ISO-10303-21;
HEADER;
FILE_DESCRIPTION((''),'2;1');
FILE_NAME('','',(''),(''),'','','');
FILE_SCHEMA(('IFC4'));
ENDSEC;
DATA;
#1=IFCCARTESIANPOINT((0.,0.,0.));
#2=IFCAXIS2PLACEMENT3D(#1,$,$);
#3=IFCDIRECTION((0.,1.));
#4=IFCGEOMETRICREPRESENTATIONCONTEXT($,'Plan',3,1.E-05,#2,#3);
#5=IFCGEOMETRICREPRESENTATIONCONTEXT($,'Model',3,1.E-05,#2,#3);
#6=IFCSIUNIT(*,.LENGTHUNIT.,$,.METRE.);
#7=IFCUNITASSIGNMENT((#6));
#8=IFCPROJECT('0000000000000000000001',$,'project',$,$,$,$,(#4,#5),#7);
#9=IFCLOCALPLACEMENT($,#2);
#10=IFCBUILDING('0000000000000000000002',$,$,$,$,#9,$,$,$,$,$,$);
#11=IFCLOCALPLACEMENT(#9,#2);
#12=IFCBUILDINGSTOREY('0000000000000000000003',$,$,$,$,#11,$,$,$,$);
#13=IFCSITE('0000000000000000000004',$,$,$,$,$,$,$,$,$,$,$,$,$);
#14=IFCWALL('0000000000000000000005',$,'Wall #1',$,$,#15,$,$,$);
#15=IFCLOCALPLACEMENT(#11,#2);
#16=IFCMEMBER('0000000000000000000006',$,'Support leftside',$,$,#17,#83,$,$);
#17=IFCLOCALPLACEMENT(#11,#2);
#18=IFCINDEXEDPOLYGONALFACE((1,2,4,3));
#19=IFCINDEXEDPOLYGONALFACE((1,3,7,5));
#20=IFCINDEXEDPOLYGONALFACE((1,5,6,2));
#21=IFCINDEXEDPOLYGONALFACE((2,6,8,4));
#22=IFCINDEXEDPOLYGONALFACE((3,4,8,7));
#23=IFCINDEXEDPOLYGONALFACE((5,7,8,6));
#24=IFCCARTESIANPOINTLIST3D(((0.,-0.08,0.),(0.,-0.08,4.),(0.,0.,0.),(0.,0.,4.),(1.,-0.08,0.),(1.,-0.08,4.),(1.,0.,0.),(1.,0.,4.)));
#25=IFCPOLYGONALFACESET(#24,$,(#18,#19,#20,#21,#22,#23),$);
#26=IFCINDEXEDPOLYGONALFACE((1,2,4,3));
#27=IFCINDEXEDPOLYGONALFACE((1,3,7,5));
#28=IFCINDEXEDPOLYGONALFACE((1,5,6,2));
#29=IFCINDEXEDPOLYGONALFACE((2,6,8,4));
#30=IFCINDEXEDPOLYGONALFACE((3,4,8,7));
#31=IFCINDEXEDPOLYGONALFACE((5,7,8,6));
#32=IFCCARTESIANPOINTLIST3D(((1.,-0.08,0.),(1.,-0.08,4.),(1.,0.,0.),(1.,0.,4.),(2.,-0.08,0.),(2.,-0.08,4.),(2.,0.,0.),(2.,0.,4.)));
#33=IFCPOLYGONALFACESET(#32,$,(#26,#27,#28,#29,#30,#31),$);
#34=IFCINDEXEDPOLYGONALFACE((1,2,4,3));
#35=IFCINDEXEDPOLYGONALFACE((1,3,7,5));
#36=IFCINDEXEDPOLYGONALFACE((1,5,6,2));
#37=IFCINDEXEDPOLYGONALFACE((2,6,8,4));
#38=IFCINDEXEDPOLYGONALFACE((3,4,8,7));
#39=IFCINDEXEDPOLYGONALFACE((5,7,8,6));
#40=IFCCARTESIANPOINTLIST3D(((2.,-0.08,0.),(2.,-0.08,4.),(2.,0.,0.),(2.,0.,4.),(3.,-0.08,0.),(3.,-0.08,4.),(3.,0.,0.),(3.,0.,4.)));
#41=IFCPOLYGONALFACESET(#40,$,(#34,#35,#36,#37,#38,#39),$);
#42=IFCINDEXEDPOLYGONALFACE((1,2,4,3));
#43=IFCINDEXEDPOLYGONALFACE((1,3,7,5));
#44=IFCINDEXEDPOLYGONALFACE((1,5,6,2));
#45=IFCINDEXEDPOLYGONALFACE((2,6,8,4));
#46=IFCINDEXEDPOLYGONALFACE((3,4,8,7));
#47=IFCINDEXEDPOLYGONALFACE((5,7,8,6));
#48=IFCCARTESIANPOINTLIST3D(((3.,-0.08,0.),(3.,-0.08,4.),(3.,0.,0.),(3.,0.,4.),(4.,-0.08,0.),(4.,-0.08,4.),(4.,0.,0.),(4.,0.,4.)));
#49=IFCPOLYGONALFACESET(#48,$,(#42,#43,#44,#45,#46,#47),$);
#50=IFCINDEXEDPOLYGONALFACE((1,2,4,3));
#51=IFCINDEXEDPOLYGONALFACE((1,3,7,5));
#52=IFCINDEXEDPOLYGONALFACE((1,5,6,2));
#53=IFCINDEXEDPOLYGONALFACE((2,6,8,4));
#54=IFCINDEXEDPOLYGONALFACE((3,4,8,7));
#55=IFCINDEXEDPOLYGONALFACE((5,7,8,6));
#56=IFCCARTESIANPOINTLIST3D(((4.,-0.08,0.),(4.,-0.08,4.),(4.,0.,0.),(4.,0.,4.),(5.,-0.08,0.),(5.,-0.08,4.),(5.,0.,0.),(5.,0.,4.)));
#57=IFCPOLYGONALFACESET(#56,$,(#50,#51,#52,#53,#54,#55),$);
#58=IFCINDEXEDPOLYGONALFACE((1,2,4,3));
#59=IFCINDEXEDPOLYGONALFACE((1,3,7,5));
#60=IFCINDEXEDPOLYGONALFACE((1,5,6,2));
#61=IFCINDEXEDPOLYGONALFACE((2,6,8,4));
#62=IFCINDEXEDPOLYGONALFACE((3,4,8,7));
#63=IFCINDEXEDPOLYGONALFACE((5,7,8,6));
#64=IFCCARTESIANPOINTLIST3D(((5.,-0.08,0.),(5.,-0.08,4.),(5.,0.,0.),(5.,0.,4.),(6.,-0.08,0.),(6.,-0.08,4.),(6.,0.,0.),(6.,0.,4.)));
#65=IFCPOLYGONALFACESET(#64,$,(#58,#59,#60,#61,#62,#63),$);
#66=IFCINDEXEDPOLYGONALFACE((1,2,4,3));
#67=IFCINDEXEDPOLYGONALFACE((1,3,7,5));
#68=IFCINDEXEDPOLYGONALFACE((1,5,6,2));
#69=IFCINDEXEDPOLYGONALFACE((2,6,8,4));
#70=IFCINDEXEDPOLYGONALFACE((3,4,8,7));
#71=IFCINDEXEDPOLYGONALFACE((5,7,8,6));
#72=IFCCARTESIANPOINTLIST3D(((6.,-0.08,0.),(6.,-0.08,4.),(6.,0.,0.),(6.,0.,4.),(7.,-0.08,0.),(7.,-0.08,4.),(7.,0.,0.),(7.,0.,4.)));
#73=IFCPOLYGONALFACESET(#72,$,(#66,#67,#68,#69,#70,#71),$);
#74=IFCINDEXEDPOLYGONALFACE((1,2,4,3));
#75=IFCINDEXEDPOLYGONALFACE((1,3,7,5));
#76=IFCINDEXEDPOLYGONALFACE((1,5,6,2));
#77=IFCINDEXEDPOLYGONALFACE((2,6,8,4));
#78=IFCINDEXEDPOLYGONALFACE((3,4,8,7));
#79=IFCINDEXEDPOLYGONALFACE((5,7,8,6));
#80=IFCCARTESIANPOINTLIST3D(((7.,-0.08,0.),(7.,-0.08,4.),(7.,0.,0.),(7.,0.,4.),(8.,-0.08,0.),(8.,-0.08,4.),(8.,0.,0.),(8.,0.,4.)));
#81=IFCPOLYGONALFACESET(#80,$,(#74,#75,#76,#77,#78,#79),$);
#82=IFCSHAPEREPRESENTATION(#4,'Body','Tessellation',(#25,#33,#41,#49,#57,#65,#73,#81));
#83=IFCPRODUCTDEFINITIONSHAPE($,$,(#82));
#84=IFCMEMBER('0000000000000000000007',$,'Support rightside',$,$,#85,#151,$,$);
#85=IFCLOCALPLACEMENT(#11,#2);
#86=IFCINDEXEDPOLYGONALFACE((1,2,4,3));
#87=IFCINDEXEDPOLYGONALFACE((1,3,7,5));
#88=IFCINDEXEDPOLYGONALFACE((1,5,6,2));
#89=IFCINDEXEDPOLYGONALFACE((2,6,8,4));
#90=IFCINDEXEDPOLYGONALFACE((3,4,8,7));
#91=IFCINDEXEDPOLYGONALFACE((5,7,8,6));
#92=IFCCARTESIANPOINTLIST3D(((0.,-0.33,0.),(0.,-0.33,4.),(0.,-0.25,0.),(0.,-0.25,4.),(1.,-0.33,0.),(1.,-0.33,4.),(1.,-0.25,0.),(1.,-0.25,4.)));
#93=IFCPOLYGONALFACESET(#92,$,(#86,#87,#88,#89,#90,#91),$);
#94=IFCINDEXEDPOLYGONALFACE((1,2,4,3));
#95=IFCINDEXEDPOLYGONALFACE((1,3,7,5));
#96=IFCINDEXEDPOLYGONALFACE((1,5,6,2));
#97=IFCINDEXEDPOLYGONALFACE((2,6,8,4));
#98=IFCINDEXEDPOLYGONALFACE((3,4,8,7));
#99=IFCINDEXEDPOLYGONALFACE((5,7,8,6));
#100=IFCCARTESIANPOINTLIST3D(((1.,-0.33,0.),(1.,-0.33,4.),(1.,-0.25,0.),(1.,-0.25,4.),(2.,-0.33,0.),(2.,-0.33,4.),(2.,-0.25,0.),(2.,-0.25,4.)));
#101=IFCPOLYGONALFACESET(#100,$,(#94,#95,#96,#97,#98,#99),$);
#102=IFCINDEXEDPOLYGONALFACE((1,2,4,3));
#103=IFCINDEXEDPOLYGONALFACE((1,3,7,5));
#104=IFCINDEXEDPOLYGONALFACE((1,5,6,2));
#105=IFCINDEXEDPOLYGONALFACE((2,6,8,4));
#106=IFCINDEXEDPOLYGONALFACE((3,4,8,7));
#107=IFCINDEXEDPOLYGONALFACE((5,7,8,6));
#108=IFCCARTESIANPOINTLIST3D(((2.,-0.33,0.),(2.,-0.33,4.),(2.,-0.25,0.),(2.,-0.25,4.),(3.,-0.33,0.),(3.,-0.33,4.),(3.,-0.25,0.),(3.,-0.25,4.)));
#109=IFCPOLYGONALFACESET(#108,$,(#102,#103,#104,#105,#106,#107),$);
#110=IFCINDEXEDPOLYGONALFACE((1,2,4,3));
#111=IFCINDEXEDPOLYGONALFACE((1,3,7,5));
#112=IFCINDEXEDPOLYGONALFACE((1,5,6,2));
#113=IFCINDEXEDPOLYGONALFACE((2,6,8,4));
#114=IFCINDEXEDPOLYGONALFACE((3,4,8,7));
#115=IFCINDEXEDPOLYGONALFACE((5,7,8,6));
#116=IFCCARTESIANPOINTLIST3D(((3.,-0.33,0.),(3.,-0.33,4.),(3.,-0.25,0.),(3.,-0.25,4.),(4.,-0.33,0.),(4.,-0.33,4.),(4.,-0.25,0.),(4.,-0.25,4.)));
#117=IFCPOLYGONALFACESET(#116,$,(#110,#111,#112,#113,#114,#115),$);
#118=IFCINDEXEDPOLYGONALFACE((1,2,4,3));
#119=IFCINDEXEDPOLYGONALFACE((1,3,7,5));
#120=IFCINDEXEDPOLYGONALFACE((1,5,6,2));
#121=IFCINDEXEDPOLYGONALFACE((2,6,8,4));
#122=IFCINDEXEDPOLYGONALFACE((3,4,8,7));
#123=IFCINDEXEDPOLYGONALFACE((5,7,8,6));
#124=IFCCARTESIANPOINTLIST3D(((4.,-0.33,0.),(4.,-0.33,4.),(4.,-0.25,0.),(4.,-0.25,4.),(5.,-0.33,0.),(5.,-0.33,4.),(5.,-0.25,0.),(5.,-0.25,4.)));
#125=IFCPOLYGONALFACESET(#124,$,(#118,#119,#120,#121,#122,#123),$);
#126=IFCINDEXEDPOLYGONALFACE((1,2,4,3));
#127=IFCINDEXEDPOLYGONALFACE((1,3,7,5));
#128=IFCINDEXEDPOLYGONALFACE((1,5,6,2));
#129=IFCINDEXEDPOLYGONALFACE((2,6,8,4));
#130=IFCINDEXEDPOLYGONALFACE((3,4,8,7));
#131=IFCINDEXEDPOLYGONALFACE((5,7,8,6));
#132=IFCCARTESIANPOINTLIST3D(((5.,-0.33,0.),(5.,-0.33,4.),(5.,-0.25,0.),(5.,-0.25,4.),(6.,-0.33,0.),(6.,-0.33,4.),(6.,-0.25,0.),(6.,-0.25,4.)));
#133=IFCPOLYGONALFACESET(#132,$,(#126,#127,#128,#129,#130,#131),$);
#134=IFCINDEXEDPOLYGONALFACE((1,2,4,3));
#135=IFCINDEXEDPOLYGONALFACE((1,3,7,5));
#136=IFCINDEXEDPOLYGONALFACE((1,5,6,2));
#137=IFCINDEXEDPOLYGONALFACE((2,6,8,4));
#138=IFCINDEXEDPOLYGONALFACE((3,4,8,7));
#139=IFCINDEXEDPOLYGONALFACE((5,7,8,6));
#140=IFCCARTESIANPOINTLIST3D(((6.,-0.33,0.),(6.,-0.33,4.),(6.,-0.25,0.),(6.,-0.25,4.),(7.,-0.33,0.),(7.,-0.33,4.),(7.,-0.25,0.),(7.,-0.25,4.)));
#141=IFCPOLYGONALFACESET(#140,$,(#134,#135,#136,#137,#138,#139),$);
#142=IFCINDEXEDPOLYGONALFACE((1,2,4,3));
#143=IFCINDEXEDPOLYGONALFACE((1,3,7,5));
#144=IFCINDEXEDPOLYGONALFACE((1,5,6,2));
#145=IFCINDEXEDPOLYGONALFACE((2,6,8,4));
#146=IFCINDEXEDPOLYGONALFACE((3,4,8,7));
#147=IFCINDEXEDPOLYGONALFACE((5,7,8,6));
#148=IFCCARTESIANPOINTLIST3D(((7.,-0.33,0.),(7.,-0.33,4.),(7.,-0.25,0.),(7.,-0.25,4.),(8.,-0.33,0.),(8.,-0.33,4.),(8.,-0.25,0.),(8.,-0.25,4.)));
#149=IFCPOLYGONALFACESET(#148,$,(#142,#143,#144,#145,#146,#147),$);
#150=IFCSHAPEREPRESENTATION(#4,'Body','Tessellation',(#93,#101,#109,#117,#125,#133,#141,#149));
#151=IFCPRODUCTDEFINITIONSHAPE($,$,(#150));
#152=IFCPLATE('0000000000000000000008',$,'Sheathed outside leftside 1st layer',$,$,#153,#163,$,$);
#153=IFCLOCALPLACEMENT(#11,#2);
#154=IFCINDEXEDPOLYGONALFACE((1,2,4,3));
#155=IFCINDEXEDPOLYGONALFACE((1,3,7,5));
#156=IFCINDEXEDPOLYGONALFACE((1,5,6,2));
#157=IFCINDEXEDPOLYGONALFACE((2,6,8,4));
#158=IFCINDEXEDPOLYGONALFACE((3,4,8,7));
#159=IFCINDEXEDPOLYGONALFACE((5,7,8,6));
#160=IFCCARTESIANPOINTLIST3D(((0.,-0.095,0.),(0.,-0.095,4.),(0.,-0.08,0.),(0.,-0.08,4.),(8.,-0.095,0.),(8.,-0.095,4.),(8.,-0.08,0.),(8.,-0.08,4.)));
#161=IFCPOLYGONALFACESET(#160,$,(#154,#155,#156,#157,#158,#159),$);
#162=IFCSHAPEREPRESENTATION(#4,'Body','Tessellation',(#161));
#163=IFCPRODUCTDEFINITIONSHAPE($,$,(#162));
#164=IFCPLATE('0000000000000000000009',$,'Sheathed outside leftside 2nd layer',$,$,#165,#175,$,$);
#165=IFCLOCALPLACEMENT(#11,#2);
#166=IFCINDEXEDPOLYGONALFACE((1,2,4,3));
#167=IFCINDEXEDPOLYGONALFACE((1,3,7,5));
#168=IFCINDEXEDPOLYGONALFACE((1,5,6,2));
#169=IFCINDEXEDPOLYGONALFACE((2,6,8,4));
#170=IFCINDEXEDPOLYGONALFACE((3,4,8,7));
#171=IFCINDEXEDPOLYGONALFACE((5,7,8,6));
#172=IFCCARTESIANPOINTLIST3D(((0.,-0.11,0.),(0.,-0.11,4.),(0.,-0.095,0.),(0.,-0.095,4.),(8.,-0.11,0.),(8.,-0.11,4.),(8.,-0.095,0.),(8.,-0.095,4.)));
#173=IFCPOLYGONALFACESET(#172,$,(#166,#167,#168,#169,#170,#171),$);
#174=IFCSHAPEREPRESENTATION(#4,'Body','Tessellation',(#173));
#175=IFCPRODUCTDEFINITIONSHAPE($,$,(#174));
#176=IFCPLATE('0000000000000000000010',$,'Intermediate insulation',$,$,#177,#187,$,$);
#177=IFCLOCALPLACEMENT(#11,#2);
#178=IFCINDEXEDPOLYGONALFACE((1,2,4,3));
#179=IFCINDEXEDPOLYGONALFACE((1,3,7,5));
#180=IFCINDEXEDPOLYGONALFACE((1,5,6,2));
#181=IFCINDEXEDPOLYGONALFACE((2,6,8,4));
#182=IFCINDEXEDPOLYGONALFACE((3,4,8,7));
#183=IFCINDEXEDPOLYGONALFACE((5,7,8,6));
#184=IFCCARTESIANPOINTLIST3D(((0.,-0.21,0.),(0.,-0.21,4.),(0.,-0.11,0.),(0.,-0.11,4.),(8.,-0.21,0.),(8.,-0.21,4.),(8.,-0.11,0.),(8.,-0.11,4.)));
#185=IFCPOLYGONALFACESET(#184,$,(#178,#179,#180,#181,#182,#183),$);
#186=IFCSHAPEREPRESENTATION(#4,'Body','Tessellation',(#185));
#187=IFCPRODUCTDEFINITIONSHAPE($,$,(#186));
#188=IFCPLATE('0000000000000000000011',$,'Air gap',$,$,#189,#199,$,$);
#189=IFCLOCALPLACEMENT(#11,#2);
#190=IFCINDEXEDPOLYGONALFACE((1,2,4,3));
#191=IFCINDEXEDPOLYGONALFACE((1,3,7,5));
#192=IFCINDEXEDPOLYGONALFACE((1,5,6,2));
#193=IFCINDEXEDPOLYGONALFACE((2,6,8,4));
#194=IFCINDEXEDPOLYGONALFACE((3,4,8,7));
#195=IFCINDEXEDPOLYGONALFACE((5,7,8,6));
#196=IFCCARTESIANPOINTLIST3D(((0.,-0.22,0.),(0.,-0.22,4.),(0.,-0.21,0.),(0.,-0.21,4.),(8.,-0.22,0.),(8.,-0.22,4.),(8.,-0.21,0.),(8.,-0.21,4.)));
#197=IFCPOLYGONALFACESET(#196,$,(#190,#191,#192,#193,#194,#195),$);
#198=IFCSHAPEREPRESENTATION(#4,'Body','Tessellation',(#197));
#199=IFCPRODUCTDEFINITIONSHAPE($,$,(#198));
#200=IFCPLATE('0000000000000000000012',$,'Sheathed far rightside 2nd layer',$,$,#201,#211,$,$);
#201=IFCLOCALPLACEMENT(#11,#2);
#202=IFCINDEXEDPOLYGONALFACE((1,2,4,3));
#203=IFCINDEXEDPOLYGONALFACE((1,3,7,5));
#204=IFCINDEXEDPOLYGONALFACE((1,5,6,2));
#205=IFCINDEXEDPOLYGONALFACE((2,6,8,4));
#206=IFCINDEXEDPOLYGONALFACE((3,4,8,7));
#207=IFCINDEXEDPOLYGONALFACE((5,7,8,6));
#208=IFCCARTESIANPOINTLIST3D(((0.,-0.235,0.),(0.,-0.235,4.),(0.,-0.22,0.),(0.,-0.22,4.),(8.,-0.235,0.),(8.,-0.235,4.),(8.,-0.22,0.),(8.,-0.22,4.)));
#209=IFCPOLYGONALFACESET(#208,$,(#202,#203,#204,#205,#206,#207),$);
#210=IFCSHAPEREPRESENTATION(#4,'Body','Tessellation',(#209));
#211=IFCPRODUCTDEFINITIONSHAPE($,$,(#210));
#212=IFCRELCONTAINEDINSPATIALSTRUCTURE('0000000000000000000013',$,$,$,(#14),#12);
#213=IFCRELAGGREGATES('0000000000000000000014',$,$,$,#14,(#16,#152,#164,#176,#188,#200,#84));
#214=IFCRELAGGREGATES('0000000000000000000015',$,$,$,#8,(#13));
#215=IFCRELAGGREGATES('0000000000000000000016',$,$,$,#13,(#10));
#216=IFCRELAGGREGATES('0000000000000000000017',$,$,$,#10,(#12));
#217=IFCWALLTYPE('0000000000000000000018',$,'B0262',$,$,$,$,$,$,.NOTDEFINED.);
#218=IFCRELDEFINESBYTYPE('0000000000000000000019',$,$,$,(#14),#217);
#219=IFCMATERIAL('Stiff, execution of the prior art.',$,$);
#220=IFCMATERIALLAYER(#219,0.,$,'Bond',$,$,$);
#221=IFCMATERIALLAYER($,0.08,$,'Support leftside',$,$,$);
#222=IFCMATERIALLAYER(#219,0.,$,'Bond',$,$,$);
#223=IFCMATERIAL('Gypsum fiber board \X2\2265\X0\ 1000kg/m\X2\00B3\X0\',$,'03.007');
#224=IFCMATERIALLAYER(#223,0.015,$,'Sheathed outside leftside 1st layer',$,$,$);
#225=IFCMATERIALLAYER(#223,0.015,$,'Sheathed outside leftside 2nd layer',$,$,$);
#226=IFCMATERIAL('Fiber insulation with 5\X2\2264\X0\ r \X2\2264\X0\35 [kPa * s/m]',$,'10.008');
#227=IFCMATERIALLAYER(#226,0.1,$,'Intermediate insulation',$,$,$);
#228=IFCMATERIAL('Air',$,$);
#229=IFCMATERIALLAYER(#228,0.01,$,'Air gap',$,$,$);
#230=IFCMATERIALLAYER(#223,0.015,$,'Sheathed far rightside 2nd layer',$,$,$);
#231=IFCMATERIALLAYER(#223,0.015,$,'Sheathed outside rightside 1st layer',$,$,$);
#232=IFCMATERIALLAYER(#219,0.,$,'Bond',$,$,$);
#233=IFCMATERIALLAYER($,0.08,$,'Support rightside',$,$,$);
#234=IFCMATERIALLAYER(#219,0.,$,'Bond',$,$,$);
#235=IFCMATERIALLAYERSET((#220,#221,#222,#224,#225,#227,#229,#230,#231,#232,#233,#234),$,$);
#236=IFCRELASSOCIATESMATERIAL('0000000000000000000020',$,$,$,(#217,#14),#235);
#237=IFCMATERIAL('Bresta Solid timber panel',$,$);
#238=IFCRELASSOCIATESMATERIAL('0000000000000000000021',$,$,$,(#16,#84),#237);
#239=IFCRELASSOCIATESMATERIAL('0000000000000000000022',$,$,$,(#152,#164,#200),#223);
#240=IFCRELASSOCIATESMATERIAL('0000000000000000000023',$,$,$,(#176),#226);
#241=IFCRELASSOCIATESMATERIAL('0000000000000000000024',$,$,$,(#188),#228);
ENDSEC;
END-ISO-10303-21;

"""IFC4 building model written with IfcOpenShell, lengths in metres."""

from ifc_helpers import new_model, si_unit, direction, frame, frame_2d, origin, place, context, project, spatial, rectangle, extrude, material, layer, layer_set, type_object, element, aggregate, save


model = new_model("IFC4")

# Units and contexts
plan_context = context("Plan", 3, precision=1e-05, world=origin(), true_north=direction((0.0, 1.0)))
model_context = context("Model", 3, precision=1e-05, world=origin(), true_north=direction((0.0, 1.0)))
ifc_project = project(units=[si_unit("LENGTHUNIT", "METRE")], contexts=[plan_context, model_context])

# Site, building, storey
site = spatial("IfcSite", under=ifc_project)
building_placement = place(None, origin())
building = spatial("IfcBuilding", under=site, at=building_placement)
storey_placement = place(building_placement, origin())
storey = spatial("IfcBuildingStorey", under=building, at=storey_placement)

# Wall, members, plates
ifc_material_1 = material(Name="Stiff, execution of the prior art.")
ifc_layer_1 = layer(ifc_material_1, 0.0, Name="Bond")
ifc_layer_2 = layer(None, 0.08, Name="Support leftside")
ifc_layer_3 = layer(ifc_material_1, 0.0, Name="Bond")
ifc_material_2 = material(Name="Gypsum fiber board ≥ 1000kg/m³", Category="03.007")
ifc_layer_4 = layer(ifc_material_2, 0.015, Name="Sheathed outside leftside 1st layer")
ifc_layer_5 = layer(ifc_material_2, 0.015, Name="Sheathed outside leftside 2nd layer")
ifc_material_3 = material(Name="Fiber insulation with 5≤ r ≤35 [kPa * s/m]", Category="10.008")
ifc_layer_6 = layer(ifc_material_3, 0.1, Name="Intermediate insulation")
ifc_material_4 = material(Name="Air")
ifc_layer_7 = layer(ifc_material_4, 0.01, Name="Air gap")
ifc_layer_8 = layer(ifc_material_2, 0.015, Name="Sheathed far rightside 2nd layer")
ifc_layer_9 = layer(ifc_material_2, 0.015, Name="Sheathed outside rightside 1st layer")
ifc_layer_10 = layer(ifc_material_1, 0.0, Name="Bond")
ifc_layer_11 = layer(None, 0.08, Name="Support rightside")
ifc_layer_12 = layer(ifc_material_1, 0.0, Name="Bond")
ifc_layer_set = layer_set([ifc_layer_1, ifc_layer_2, ifc_layer_3, ifc_layer_4, ifc_layer_5, ifc_layer_6, ifc_layer_7, ifc_layer_8, ifc_layer_9, ifc_layer_10, ifc_layer_11, ifc_layer_12])
wall_type = type_object("IfcWallType", Name="B0262", PredefinedType="NOTDEFINED", material=ifc_layer_set)
wall_placement = place(None, frame((0.0, 0.0, 0.0), z_axis=(0.0, -1.0, 0.0), x_axis=(1.0, 0.0, 0.0)))
wall = element("IfcWall", 1, at=wall_placement, inside=storey, type_object=wall_type, material=ifc_layer_set, Name="Wall #1")
ifc_material_5 = material(Name="Bresta Solid timber panel")
member_1_placement = place(wall_placement, origin())
member_1 = element("IfcMember", 2, at=member_1_placement, material=ifc_material_5, Name="Support leftside", context=plan_context, shape_type="SweptSolid", body=[
    extrude(rectangle(XDim=1.0, YDim=0.08, at=frame_2d((0.5, 0.04), x_axis=(1.0, 0.0))), frame((0.0, 4.0, 0.0), z_axis=(0.0, -1.0, 0.0), x_axis=(1.0, 0.0, 0.0)), (0.0, 0.0, 1.0), 4.0),
    extrude(rectangle(XDim=1.0, YDim=0.08, at=frame_2d((0.5, 0.04), x_axis=(1.0, 0.0))), frame((1.0, 4.0, 0.0), z_axis=(0.0, -1.0, 0.0), x_axis=(1.0, 0.0, 0.0)), (0.0, 0.0, 1.0), 4.0),
    extrude(rectangle(XDim=1.0, YDim=0.08, at=frame_2d((0.5, 0.04), x_axis=(1.0, 0.0))), frame((2.0, 4.0, 0.0), z_axis=(0.0, -1.0, 0.0), x_axis=(1.0, 0.0, 0.0)), (0.0, 0.0, 1.0), 4.0),
    extrude(rectangle(XDim=1.0, YDim=0.08, at=frame_2d((0.5, 0.04), x_axis=(1.0, 0.0))), frame((3.0, 4.0, 0.0), z_axis=(0.0, -1.0, 0.0), x_axis=(1.0, 0.0, 0.0)), (0.0, 0.0, 1.0), 4.0),
    extrude(rectangle(XDim=1.0, YDim=0.08, at=frame_2d((0.5, 0.04), x_axis=(1.0, 0.0))), frame((4.0, 4.0, 0.0), z_axis=(0.0, -1.0, 0.0), x_axis=(1.0, 0.0, 0.0)), (0.0, 0.0, 1.0), 4.0),
    extrude(rectangle(XDim=1.0, YDim=0.08, at=frame_2d((0.5, 0.04), x_axis=(1.0, 0.0))), frame((5.0, 4.0, 0.0), z_axis=(0.0, -1.0, 0.0), x_axis=(1.0, 0.0, 0.0)), (0.0, 0.0, 1.0), 4.0),
    extrude(rectangle(XDim=1.0, YDim=0.08, at=frame_2d((0.5, 0.04), x_axis=(1.0, 0.0))), frame((6.0, 4.0, 0.0), z_axis=(0.0, -1.0, 0.0), x_axis=(1.0, 0.0, 0.0)), (0.0, 0.0, 1.0), 4.0),
    extrude(rectangle(XDim=1.0, YDim=0.08, at=frame_2d((0.5, 0.04), x_axis=(1.0, 0.0))), frame((7.0, 4.0, 0.0), z_axis=(0.0, -1.0, 0.0), x_axis=(1.0, 0.0, 0.0)), (0.0, 0.0, 1.0), 4.0),
])
member_2_placement = place(wall_placement, origin())
member_2 = element("IfcMember", 3, at=member_2_placement, material=ifc_material_5, Name="Support rightside", context=plan_context, shape_type="SweptSolid", body=[
    extrude(rectangle(XDim=1.0, YDim=0.08, at=frame_2d((0.5, 0.04), x_axis=(1.0, 0.0))), frame((0.0, 4.0, 0.25), z_axis=(0.0, -1.0, 0.0), x_axis=(1.0, 0.0, 0.0)), (0.0, 0.0, 1.0), 4.0),
    extrude(rectangle(XDim=1.0, YDim=0.08, at=frame_2d((0.5, 0.04), x_axis=(1.0, 0.0))), frame((1.0, 4.0, 0.25), z_axis=(0.0, -1.0, 0.0), x_axis=(1.0, 0.0, 0.0)), (0.0, 0.0, 1.0), 4.0),
    extrude(rectangle(XDim=1.0, YDim=0.08, at=frame_2d((0.5, 0.04), x_axis=(1.0, 0.0))), frame((2.0, 4.0, 0.25), z_axis=(0.0, -1.0, 0.0), x_axis=(1.0, 0.0, 0.0)), (0.0, 0.0, 1.0), 4.0),
    extrude(rectangle(XDim=1.0, YDim=0.08, at=frame_2d((0.5, 0.04), x_axis=(1.0, 0.0))), frame((3.0, 4.0, 0.25), z_axis=(0.0, -1.0, 0.0), x_axis=(1.0, 0.0, 0.0)), (0.0, 0.0, 1.0), 4.0),
    extrude(rectangle(XDim=1.0, YDim=0.08, at=frame_2d((0.5, 0.04), x_axis=(1.0, 0.0))), frame((4.0, 4.0, 0.25), z_axis=(0.0, -1.0, 0.0), x_axis=(1.0, 0.0, 0.0)), (0.0, 0.0, 1.0), 4.0),
    extrude(rectangle(XDim=1.0, YDim=0.08, at=frame_2d((0.5, 0.04), x_axis=(1.0, 0.0))), frame((5.0, 4.0, 0.25), z_axis=(0.0, -1.0, 0.0), x_axis=(1.0, 0.0, 0.0)), (0.0, 0.0, 1.0), 4.0),
    extrude(rectangle(XDim=1.0, YDim=0.08, at=frame_2d((0.5, 0.04), x_axis=(1.0, 0.0))), frame((6.0, 4.0, 0.25), z_axis=(0.0, -1.0, 0.0), x_axis=(1.0, 0.0, 0.0)), (0.0, 0.0, 1.0), 4.0),
    extrude(rectangle(XDim=1.0, YDim=0.08, at=frame_2d((0.5, 0.04), x_axis=(1.0, 0.0))), frame((7.0, 4.0, 0.25), z_axis=(0.0, -1.0, 0.0), x_axis=(1.0, 0.0, 0.0)), (0.0, 0.0, 1.0), 4.0),
])
plate_1_placement = place(wall_placement, origin())
plate_1 = element("IfcPlate", 4, at=plate_1_placement, material=ifc_material_2, Name="Sheathed outside leftside 1st layer", context=plan_context, shape_type="SweptSolid", body=[
    extrude(rectangle(XDim=8.0, YDim=4.0, at=frame_2d((4.0, 2.0), x_axis=(1.0, 0.0))), frame((0.0, 0.0, 0.08), z_axis=(0.0, 0.0, 1.0), x_axis=(1.0, 0.0, 0.0)), (0.0, 0.0, 1.0), 0.015),
])
plate_2_placement = place(wall_placement, origin())
plate_2 = element("IfcPlate", 5, at=plate_2_placement, material=ifc_material_2, Name="Sheathed outside leftside 2nd layer", context=plan_context, shape_type="SweptSolid", body=[
    extrude(rectangle(XDim=8.0, YDim=4.0, at=frame_2d((4.0, 2.0), x_axis=(1.0, 0.0))), frame((0.0, 0.0, 0.095), z_axis=(0.0, 0.0, 1.0), x_axis=(1.0, 0.0, 0.0)), (0.0, 0.0, 1.0), 0.015),
])
plate_3_placement = place(wall_placement, origin())
plate_3 = element("IfcPlate", 6, at=plate_3_placement, material=ifc_material_3, Name="Intermediate insulation", context=plan_context, shape_type="SweptSolid", body=[
    extrude(rectangle(XDim=8.0, YDim=4.0, at=frame_2d((4.0, 2.0), x_axis=(1.0, 0.0))), frame((0.0, 0.0, 0.11), z_axis=(0.0, 0.0, 1.0), x_axis=(1.0, 0.0, 0.0)), (0.0, 0.0, 1.0), 0.1),
])
plate_4_placement = place(wall_placement, origin())
plate_4 = element("IfcPlate", 7, at=plate_4_placement, material=ifc_material_4, Name="Air gap", context=plan_context, shape_type="SweptSolid", body=[
    extrude(rectangle(XDim=8.0, YDim=4.0, at=frame_2d((4.0, 2.0), x_axis=(1.0, 0.0))), frame((0.0, 0.0, 0.21), z_axis=(0.0, 0.0, 1.0), x_axis=(1.0, 0.0, 0.0)), (0.0, 0.0, 1.0), 0.01),
])
plate_5_placement = place(wall_placement, origin())
plate_5 = element("IfcPlate", 8, at=plate_5_placement, material=ifc_material_2, Name="Sheathed far rightside 2nd layer", context=plan_context, shape_type="SweptSolid", body=[
    extrude(rectangle(XDim=8.0, YDim=4.0, at=frame_2d((4.0, 2.0), x_axis=(1.0, 0.0))), frame((0.0, 0.0, 0.22), z_axis=(0.0, 0.0, 1.0), x_axis=(1.0, 0.0, 0.0)), (0.0, 0.0, 1.0), 0.015),
])
aggregate(wall, [member_1, plate_1, plate_2, plate_3, plate_4, plate_5, member_2])

save(model, "model.ifc")
